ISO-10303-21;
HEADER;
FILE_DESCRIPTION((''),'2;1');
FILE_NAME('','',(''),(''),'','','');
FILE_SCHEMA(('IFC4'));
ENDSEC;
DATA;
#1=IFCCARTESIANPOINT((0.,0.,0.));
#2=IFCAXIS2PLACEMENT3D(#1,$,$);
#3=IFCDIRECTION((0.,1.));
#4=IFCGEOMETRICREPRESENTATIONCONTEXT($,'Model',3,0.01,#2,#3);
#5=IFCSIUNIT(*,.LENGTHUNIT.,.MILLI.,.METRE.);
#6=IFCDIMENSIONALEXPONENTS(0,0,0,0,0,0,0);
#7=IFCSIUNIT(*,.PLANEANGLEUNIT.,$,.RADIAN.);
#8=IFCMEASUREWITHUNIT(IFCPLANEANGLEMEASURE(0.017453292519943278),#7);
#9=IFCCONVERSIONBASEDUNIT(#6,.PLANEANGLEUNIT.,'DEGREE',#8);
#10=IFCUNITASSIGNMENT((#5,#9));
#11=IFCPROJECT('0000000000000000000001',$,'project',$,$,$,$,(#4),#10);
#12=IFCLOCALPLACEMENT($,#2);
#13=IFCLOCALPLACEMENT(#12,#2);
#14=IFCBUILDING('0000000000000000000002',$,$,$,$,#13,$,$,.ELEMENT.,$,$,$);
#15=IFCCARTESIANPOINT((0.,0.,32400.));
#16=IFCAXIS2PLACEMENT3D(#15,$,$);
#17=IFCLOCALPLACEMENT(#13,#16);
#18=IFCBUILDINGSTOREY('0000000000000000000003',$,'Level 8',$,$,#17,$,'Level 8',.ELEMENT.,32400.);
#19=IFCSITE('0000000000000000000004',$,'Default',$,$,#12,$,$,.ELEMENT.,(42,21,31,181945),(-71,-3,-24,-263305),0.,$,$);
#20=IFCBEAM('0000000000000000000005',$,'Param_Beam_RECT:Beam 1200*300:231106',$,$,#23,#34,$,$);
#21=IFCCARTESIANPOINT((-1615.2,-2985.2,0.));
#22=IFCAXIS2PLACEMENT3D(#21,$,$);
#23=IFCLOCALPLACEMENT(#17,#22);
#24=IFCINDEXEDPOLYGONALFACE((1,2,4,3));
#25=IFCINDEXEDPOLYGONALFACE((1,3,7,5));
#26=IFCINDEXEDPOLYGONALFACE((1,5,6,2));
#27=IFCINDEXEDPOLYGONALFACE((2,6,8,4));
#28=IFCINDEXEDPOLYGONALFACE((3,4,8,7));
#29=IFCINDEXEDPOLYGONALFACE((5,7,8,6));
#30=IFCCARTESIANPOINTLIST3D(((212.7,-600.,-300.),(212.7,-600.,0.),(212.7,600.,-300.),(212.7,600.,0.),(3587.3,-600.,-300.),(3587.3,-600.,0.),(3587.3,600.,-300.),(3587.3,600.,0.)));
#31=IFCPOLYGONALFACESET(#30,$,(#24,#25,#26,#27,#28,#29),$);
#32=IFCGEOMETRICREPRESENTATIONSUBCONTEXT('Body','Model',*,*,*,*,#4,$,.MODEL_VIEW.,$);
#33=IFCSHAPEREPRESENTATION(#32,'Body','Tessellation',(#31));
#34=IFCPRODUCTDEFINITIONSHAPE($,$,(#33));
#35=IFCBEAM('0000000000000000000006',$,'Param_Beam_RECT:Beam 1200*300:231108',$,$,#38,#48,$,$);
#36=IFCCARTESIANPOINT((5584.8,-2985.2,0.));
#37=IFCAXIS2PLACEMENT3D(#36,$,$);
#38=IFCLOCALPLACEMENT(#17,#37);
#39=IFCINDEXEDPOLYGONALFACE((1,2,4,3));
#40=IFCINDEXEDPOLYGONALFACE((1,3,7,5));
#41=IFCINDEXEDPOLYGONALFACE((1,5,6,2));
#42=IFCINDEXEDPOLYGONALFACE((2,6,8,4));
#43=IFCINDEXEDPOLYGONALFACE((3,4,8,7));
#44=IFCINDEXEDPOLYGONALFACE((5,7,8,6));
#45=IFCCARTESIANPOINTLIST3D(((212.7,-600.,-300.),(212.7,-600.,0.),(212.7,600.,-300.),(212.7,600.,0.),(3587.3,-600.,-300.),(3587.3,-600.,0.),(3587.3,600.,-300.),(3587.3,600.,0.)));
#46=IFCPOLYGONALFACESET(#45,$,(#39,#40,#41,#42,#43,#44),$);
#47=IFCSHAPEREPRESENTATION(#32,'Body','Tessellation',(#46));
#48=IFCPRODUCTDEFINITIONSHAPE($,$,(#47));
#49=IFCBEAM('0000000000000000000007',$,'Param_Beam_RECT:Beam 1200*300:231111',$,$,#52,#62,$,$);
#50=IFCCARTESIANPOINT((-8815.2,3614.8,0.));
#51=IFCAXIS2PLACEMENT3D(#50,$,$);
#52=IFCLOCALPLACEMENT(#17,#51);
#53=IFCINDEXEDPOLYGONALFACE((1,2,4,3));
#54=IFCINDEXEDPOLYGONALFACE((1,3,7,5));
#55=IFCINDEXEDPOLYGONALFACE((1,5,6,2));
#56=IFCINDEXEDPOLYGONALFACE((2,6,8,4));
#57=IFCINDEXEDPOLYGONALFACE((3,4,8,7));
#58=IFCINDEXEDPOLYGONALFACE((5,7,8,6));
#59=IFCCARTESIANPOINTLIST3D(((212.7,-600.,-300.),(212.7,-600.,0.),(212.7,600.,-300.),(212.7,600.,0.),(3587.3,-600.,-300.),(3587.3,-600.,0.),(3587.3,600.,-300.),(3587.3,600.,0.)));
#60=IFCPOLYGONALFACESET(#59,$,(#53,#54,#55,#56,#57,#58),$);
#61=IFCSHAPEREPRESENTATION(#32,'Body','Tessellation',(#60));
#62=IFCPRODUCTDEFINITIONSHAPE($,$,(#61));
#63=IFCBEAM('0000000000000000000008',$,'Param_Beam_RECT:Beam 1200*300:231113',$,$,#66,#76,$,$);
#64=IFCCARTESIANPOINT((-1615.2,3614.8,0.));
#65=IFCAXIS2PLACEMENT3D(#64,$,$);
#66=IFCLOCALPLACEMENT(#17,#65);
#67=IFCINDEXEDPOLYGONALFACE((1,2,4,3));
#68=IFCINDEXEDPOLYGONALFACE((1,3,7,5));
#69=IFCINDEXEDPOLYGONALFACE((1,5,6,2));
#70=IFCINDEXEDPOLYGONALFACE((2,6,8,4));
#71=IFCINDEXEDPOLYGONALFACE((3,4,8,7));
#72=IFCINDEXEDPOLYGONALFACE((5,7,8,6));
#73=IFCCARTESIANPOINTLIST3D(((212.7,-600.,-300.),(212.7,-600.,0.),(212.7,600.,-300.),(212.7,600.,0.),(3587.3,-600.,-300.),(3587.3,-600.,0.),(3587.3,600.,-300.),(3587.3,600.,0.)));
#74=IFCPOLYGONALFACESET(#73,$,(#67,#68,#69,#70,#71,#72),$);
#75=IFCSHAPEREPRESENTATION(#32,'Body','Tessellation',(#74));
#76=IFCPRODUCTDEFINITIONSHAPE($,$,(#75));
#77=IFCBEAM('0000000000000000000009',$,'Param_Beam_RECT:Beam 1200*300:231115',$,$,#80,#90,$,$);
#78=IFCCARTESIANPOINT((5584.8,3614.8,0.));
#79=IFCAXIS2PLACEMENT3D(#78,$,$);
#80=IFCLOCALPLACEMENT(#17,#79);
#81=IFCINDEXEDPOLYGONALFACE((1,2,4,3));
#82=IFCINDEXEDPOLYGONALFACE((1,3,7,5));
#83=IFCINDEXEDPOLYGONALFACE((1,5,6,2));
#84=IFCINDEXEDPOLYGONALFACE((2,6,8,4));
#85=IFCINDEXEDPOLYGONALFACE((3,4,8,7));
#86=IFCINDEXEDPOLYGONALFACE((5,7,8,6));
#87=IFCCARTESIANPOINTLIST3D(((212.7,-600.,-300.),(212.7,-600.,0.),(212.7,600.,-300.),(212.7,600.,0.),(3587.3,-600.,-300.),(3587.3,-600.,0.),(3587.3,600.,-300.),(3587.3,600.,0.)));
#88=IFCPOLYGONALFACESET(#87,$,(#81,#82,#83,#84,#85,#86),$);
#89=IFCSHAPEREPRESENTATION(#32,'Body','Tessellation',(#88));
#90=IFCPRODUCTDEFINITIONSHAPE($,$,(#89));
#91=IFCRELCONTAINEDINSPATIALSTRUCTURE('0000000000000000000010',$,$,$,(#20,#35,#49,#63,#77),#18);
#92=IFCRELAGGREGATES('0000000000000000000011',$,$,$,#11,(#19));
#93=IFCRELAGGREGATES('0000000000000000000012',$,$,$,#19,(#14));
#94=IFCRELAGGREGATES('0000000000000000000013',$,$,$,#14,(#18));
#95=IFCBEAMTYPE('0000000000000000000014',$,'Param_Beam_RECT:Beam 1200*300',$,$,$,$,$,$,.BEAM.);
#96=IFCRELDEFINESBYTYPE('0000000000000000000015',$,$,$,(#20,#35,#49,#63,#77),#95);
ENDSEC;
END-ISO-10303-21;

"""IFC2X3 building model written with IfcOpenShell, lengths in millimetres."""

from ifc_helpers import new_model, entity, si_unit, converted_unit, direction, frame, frame_2d, origin, place, context, subcontext, project, spatial, rectangle, extrude, type_object, element, save


model = new_model("IFC2X3")

# Units and contexts
model_context = context("Model", 3, precision=0.01, world=origin(), true_north=direction((0.0, 1.0)))
body_context = subcontext(model_context, "Body", "Model", "MODEL_VIEW")
ifc_project = project(units=[si_unit("LENGTHUNIT", "METRE", prefix="MILLI"), converted_unit("PLANEANGLEUNIT", "DEGREE", entity("IfcPlaneAngleMeasure", 0.017453292519943278), si_unit("PLANEANGLEUNIT", "RADIAN"), dimensions=[0, 0, 0, 0, 0, 0, 0])], contexts=[model_context])

# Site, building, storey
site_placement = place(None, origin())
site = spatial("IfcSite", under=ifc_project, at=site_placement, Name="Default", CompositionType="ELEMENT", RefLatitude=(42, 21, 31, 181945), RefLongitude=(-71, -3, -24, -263305), RefElevation=0.0)
building_placement = place(site_placement, origin())
building = spatial("IfcBuilding", under=site, at=building_placement, CompositionType="ELEMENT")
storey_placement = place(building_placement, frame((0.0, 0.0, 32400.0)))
storey = spatial("IfcBuildingStorey", under=building, at=storey_placement, Name="Level 8", LongName="Level 8", CompositionType="ELEMENT", Elevation=32400.0)

# Beams
beam_type_1 = type_object("IfcBeamType", Name="Param_Beam_RECT:Beam 1200*300", PredefinedType="BEAM")
beam_1_placement = place(storey_placement, frame((-1615.2, -2985.2, 0.0)))
element("IfcBeam", 1, at=beam_1_placement, inside=storey, type_object=beam_type_1, Name="Param_Beam_RECT:Beam 1200*300:231106", context=body_context, shape_type="SweptSolid", body=[
    extrude(rectangle(XDim=300.0, YDim=1200.0, at=frame_2d((0.0, 0.0), x_axis=(1.0, 0.0))), frame((212.7, 0.0, -150.0), z_axis=(1.0, 0.0, 0.0), x_axis=(0.0, 0.0, -1.0)), (0.0, 0.0, 1.0), 3374.6),
])
beam_2_placement = place(storey_placement, frame((5584.8, -2985.2, 0.0)))
element("IfcBeam", 2, at=beam_2_placement, inside=storey, type_object=beam_type_1, Name="Param_Beam_RECT:Beam 1200*300:231108", context=body_context, shape_type="SweptSolid", body=[
    extrude(rectangle(XDim=300.0, YDim=1200.0, at=frame_2d((0.0, 0.0), x_axis=(1.0, 0.0))), frame((212.7, 0.0, -150.0), z_axis=(1.0, 0.0, 0.0), x_axis=(0.0, 0.0, -1.0)), (0.0, 0.0, 1.0), 3374.6),
])
beam_3_placement = place(storey_placement, frame((-8815.2, 3614.8, 0.0)))
element("IfcBeam", 3, at=beam_3_placement, inside=storey, type_object=beam_type_1, Name="Param_Beam_RECT:Beam 1200*300:231111", context=body_context, shape_type="SweptSolid", body=[
    extrude(rectangle(XDim=300.0, YDim=1200.0, at=frame_2d((0.0, 0.0), x_axis=(1.0, 0.0))), frame((212.7, 0.0, -150.0), z_axis=(1.0, 0.0, 0.0), x_axis=(0.0, 0.0, -1.0)), (0.0, 0.0, 1.0), 3374.6),
])
beam_4_placement = place(storey_placement, frame((-1615.2, 3614.8, 0.0)))
element("IfcBeam", 4, at=beam_4_placement, inside=storey, type_object=beam_type_1, Name="Param_Beam_RECT:Beam 1200*300:231113", context=body_context, shape_type="SweptSolid", body=[
    extrude(rectangle(XDim=300.0, YDim=1200.0, at=frame_2d((0.0, 0.0), x_axis=(1.0, 0.0))), frame((212.7, 0.0, -150.0), z_axis=(1.0, 0.0, 0.0), x_axis=(0.0, 0.0, -1.0)), (0.0, 0.0, 1.0), 3374.6),
])
beam_5_placement = place(storey_placement, frame((5584.8, 3614.8, 0.0)))
element("IfcBeam", 5, at=beam_5_placement, inside=storey, type_object=beam_type_1, Name="Param_Beam_RECT:Beam 1200*300:231115", context=body_context, shape_type="SweptSolid", body=[
    extrude(rectangle(XDim=300.0, YDim=1200.0, at=frame_2d((0.0, 0.0), x_axis=(1.0, 0.0))), frame((212.7, 0.0, -150.0), z_axis=(1.0, 0.0, 0.0), x_axis=(0.0, 0.0, -1.0)), (0.0, 0.0, 1.0), 3374.6),
])

save(model, "model.ifc")
